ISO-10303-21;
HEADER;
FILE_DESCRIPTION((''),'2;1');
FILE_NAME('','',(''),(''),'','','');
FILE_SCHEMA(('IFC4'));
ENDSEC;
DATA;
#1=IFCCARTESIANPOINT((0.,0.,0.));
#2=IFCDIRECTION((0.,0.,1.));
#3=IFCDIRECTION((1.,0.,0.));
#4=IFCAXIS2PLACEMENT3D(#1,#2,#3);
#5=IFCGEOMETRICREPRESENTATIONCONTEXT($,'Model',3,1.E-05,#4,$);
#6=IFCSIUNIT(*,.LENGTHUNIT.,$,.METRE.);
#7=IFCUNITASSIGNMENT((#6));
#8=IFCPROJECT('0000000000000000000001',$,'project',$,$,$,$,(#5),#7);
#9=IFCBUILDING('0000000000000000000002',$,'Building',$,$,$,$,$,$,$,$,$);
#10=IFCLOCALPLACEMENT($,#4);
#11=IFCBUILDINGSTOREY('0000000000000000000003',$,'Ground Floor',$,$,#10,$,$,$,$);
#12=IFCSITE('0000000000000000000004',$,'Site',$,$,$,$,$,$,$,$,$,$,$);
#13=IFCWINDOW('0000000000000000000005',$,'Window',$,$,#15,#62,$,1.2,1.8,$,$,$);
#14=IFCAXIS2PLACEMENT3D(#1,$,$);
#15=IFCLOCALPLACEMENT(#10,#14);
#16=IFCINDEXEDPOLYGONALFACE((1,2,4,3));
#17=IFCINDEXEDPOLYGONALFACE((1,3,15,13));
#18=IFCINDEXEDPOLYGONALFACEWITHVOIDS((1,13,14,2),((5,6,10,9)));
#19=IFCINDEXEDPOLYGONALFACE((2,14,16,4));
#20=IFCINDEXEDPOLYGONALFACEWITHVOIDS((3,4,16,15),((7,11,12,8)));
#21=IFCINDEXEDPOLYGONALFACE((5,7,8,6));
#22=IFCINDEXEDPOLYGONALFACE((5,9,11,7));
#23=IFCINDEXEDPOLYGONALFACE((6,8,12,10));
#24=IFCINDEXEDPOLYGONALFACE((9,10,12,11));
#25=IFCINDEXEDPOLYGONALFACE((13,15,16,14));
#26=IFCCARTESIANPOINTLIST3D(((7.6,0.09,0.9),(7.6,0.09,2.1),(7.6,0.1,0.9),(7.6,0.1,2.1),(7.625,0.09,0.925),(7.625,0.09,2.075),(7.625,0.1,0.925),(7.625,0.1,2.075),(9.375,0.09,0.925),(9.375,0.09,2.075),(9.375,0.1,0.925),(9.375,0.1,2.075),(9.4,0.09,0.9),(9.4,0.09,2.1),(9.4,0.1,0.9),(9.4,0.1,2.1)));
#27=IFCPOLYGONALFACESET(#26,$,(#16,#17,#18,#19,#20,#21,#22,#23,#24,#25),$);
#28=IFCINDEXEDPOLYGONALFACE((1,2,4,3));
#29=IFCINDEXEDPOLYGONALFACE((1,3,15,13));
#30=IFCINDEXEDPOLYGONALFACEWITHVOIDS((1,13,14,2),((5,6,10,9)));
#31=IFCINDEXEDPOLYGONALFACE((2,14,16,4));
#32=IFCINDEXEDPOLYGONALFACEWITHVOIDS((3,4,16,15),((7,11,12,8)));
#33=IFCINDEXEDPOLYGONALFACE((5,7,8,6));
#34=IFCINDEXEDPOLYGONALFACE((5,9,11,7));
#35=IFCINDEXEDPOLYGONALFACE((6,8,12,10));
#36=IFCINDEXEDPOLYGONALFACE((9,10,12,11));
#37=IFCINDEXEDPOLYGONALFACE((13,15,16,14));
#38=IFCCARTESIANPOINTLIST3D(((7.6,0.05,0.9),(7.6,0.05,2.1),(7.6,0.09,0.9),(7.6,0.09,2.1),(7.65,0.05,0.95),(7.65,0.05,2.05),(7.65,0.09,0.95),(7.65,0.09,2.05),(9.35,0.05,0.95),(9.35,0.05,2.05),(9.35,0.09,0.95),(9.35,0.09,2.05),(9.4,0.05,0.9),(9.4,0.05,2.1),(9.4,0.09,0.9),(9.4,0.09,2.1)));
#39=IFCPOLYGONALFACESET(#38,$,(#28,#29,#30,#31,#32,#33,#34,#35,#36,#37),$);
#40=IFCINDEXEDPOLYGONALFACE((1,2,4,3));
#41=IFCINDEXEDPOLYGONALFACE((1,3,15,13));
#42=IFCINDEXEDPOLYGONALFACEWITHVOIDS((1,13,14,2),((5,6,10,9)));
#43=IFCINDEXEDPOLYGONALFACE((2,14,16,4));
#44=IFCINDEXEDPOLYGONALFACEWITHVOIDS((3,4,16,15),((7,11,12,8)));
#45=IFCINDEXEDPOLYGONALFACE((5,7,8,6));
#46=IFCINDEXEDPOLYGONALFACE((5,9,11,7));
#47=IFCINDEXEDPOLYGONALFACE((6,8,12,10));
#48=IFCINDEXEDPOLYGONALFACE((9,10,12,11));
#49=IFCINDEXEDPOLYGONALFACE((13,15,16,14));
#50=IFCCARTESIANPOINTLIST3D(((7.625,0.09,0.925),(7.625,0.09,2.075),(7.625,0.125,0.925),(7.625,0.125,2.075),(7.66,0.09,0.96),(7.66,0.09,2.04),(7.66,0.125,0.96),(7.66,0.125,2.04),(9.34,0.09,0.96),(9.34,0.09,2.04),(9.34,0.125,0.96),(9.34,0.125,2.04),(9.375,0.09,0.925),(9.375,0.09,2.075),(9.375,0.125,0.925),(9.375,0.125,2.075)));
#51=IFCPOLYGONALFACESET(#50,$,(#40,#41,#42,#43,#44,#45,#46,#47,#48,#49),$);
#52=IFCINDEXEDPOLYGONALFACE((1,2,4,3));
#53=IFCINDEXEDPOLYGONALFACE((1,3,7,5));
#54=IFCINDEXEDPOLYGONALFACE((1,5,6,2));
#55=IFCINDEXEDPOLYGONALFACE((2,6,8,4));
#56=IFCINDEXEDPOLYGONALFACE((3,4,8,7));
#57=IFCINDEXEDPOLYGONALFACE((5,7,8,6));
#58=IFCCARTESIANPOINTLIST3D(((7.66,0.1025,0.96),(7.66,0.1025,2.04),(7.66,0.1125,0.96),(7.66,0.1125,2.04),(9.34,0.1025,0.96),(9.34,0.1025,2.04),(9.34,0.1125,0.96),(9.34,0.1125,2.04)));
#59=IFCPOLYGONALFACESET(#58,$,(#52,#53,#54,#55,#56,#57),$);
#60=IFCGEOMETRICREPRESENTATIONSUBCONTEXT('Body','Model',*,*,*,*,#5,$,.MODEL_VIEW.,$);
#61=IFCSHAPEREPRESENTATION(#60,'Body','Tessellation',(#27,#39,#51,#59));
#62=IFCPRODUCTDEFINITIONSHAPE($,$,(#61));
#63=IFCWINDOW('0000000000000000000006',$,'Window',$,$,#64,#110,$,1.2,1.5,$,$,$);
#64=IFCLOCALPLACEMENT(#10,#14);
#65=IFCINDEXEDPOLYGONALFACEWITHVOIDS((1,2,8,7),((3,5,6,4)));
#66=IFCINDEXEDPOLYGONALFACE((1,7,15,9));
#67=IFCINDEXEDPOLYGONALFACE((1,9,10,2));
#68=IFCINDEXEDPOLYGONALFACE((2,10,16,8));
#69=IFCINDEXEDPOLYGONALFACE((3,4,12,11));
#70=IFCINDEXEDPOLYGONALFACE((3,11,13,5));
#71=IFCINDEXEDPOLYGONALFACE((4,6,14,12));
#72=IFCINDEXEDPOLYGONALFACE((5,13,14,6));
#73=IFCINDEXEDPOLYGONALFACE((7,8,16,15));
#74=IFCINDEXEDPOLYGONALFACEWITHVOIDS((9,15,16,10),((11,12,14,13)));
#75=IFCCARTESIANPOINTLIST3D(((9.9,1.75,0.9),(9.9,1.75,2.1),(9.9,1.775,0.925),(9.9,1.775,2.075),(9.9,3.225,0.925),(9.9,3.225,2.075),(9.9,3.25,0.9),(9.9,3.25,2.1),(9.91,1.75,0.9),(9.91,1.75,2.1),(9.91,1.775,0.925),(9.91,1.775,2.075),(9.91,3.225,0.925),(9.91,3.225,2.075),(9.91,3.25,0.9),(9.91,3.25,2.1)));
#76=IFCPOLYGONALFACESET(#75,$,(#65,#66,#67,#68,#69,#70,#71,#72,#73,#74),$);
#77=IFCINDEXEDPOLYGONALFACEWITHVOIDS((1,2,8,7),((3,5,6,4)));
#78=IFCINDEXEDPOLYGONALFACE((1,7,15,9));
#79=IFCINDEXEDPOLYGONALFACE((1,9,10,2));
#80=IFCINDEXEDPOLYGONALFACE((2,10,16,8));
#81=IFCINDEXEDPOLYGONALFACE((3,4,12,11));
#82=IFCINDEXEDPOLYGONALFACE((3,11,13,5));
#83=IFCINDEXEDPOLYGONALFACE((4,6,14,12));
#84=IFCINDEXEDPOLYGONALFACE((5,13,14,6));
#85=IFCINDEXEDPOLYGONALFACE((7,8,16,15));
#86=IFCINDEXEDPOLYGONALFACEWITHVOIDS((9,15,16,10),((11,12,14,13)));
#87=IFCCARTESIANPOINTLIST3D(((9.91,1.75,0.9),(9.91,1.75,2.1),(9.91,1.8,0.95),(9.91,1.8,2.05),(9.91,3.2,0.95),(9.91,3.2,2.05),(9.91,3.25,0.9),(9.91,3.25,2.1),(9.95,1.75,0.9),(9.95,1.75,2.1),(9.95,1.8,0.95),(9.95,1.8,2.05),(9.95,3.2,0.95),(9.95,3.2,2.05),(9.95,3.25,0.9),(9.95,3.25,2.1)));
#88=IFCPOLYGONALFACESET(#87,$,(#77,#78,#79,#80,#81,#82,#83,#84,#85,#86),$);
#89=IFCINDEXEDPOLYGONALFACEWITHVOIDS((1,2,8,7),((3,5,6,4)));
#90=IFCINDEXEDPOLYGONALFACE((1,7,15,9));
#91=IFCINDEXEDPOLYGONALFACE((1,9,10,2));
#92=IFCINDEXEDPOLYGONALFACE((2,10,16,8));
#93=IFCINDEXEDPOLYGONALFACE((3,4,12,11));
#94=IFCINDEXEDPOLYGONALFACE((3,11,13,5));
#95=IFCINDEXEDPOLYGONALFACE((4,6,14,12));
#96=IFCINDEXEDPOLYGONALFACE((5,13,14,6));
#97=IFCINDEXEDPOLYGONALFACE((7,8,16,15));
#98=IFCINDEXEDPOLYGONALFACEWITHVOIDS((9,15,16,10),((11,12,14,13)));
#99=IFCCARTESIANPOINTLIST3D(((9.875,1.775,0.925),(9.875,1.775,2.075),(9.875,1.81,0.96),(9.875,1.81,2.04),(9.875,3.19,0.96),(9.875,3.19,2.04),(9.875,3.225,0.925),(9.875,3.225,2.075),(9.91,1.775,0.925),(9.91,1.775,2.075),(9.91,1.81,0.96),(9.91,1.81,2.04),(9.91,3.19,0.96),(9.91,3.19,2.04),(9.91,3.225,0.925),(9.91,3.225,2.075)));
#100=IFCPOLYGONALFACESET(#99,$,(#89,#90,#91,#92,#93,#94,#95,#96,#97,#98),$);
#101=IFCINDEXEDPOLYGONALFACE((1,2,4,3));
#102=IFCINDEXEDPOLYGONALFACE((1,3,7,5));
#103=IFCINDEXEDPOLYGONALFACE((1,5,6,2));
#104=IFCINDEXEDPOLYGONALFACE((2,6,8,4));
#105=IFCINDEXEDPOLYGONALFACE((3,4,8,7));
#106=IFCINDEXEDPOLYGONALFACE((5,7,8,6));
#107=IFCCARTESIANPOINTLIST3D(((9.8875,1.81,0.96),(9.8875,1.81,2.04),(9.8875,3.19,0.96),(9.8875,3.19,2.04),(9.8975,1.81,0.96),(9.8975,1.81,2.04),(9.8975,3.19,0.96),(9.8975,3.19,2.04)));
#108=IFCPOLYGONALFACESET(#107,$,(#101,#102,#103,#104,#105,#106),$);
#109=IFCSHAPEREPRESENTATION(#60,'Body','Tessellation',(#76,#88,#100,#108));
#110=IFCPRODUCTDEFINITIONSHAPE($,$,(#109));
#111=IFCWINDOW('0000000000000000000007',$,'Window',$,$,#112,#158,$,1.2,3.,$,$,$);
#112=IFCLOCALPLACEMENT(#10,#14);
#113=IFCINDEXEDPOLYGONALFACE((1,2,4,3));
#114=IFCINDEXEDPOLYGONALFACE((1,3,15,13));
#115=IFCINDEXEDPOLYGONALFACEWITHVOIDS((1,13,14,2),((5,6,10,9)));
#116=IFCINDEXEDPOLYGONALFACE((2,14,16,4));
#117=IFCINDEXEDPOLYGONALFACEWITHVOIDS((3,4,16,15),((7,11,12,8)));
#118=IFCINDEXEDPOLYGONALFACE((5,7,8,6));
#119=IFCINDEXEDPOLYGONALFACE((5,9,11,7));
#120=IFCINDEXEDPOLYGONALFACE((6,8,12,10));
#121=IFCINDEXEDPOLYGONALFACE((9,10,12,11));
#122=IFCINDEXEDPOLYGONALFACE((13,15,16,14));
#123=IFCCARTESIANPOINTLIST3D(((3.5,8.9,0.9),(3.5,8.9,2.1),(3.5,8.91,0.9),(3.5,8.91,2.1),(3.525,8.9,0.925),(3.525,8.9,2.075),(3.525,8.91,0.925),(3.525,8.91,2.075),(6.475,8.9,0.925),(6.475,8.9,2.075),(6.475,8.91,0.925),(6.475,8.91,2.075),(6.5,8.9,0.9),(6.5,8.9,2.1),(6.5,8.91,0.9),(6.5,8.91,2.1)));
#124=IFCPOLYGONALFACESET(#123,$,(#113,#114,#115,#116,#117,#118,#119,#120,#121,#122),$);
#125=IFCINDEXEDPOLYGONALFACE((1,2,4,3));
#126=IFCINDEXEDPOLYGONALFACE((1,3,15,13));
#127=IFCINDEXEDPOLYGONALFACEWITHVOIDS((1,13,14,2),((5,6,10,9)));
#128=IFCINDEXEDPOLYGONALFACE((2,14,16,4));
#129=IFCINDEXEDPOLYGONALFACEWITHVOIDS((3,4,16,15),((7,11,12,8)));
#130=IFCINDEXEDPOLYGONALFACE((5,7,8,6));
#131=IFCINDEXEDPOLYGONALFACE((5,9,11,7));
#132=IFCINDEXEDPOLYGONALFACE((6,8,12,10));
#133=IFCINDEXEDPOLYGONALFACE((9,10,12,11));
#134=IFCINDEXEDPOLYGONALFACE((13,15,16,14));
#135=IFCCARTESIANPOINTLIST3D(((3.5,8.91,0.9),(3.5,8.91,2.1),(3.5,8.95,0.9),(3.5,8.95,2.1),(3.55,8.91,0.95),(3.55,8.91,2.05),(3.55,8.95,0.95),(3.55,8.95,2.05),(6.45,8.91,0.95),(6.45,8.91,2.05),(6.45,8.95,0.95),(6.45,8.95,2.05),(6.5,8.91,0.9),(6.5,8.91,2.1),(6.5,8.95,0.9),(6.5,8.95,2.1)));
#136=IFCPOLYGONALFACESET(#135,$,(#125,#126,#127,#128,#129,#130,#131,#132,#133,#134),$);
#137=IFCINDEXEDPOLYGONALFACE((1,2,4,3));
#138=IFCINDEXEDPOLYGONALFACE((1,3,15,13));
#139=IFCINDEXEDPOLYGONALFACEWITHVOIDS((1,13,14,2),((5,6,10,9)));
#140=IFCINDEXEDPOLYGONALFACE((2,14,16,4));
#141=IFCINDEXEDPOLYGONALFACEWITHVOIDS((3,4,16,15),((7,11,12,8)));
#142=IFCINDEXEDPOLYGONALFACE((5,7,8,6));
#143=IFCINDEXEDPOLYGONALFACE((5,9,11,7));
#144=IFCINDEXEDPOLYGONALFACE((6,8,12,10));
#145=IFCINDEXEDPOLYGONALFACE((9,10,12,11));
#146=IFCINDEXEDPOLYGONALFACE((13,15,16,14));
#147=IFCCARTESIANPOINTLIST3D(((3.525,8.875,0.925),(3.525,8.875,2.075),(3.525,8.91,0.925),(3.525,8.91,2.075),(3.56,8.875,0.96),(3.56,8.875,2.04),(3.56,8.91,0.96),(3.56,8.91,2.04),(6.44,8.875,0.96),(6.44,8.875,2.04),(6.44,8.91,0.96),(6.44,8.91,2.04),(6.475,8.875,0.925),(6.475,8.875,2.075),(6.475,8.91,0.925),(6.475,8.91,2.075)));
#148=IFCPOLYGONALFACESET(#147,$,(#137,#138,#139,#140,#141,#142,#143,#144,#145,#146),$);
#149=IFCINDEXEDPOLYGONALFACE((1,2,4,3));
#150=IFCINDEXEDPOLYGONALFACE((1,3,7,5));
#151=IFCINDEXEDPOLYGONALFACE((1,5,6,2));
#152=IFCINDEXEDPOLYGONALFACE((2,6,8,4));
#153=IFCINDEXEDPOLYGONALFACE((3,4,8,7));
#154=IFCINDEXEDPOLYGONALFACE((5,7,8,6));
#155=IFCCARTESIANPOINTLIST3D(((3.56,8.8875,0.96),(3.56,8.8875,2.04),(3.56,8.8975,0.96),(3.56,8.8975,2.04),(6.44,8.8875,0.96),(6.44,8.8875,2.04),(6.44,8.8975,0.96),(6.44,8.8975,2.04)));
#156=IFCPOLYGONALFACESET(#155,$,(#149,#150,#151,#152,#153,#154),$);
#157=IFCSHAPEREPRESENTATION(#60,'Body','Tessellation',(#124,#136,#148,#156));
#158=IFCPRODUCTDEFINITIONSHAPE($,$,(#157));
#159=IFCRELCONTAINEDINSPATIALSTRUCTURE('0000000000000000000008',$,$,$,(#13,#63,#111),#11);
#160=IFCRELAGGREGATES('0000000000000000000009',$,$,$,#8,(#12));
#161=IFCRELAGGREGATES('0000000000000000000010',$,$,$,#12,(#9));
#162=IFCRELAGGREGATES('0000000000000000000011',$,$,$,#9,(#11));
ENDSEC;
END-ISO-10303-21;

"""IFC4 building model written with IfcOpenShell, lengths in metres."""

from ifc_helpers import new_model, si_unit, frame, origin_with_axes, place, context, subcontext, project, spatial, line, indexed_curve, outline, extrude, element, save


model = new_model("IFC4")

# Units and contexts
model_context = context("Model", 3, precision=1e-05, world=origin_with_axes())
body_context = subcontext(model_context, "Body", "Model", "MODEL_VIEW")
ifc_project = project(units=[si_unit("LENGTHUNIT", "METRE")], contexts=[model_context])

# Site, building, storey
site = spatial("IfcSite", under=ifc_project, Name="Site")
building = spatial("IfcBuilding", under=site, Name="Building")
storey_placement = place(None, origin_with_axes())
storey = spatial("IfcBuildingStorey", under=building, at=storey_placement, Name="Ground Floor")

# Windows
window_1_placement = place(storey_placement, frame((7.6, 0.0, 0.9), z_axis=(0.0, 0.0, 1.0), x_axis=(1.0, 0.0, 0.0)))
element("IfcWindow", 1, at=window_1_placement, inside=storey, Name="Window", OverallHeight=1.2, OverallWidth=1.8, context=body_context, shape_type="SweptSolid", body=[
    extrude(outline(indexed_curve([(0.0, 0.0), (1.8, 0.0), (1.8, 1.2), (0.0, 1.2)], segments=[line(1, 2, 3, 4, 1)]), holes=[indexed_curve([(0.025, 0.025), (1.775, 0.025), (1.775, 1.175), (0.025, 1.175)], segments=[line(1, 2, 3, 4, 1)])]), frame((0.0, 0.09, 0.0), z_axis=(0.0, -1.0, 0.0), x_axis=(1.0, 0.0, 0.0)), (0.0, 0.0, -1.0), 0.01),
    extrude(outline(indexed_curve([(0.0, 0.0), (1.8, 0.0), (1.8, 1.2), (0.0, 1.2)], segments=[line(1, 2, 3, 4, 1)]), holes=[indexed_curve([(0.05, 0.05), (1.75, 0.05), (1.75, 1.15), (0.05, 1.15)], segments=[line(1, 2, 3, 4, 1)])]), frame((0.0, 0.05, 0.0), z_axis=(0.0, -1.0, 0.0), x_axis=(1.0, 0.0, 0.0)), (0.0, 0.0, -1.0), 0.04),
    extrude(outline(indexed_curve([(0.0, 0.0), (1.75, 0.0), (1.75, 1.15), (0.0, 1.15)], segments=[line(1, 2, 3, 4, 1)]), holes=[indexed_curve([(0.035, 0.035), (1.715, 0.035), (1.715, 1.115), (0.035, 1.115)], segments=[line(1, 2, 3, 4, 1)])]), frame((0.025, 0.09, 0.025), z_axis=(0.0, -1.0, 0.0), x_axis=(1.0, 0.0, 0.0)), (0.0, 0.0, -1.0), 0.035),
    extrude(outline(indexed_curve([(0.035, 0.035), (1.715, 0.035), (1.715, 1.115), (0.035, 1.115)], segments=[line(1, 2, 3, 4, 1)])), frame((0.025, 0.1025, 0.025), z_axis=(0.0, -1.0, 0.0), x_axis=(1.0, 0.0, 0.0)), (0.0, 0.0, -1.0), 0.01),
])
window_2_placement = place(storey_placement, frame((10.0, 1.75, 0.9), z_axis=(0.0, 0.0, 1.0), x_axis=(0.0, 1.0, 0.0)))
element("IfcWindow", 2, at=window_2_placement, inside=storey, Name="Window", OverallHeight=1.2, OverallWidth=1.5, context=body_context, shape_type="SweptSolid", body=[
    extrude(outline(indexed_curve([(0.0, 0.0), (1.5, 0.0), (1.5, 1.2), (0.0, 1.2)], segments=[line(1, 2, 3, 4, 1)]), holes=[indexed_curve([(0.025, 0.025), (1.475, 0.025), (1.475, 1.175), (0.025, 1.175)], segments=[line(1, 2, 3, 4, 1)])]), frame((0.0, 0.09, 0.0), z_axis=(0.0, -1.0, 0.0), x_axis=(1.0, 0.0, 0.0)), (0.0, 0.0, -1.0), 0.01),
    extrude(outline(indexed_curve([(0.0, 0.0), (1.5, 0.0), (1.5, 1.2), (0.0, 1.2)], segments=[line(1, 2, 3, 4, 1)]), holes=[indexed_curve([(0.05, 0.05), (1.45, 0.05), (1.45, 1.15), (0.05, 1.15)], segments=[line(1, 2, 3, 4, 1)])]), frame((0.0, 0.05, 0.0), z_axis=(0.0, -1.0, 0.0), x_axis=(1.0, 0.0, 0.0)), (0.0, 0.0, -1.0), 0.04),
    extrude(outline(indexed_curve([(0.0, 0.0), (1.45, 0.0), (1.45, 1.15), (0.0, 1.15)], segments=[line(1, 2, 3, 4, 1)]), holes=[indexed_curve([(0.035, 0.035), (1.415, 0.035), (1.415, 1.115), (0.035, 1.115)], segments=[line(1, 2, 3, 4, 1)])]), frame((0.025, 0.09, 0.025), z_axis=(0.0, -1.0, 0.0), x_axis=(1.0, 0.0, 0.0)), (0.0, 0.0, -1.0), 0.035),
    extrude(outline(indexed_curve([(0.035, 0.035), (1.415, 0.035), (1.415, 1.115), (0.035, 1.115)], segments=[line(1, 2, 3, 4, 1)])), frame((0.025, 0.1025, 0.025), z_axis=(0.0, -1.0, 0.0), x_axis=(1.0, 0.0, 0.0)), (0.0, 0.0, -1.0), 0.01),
])
window_3_placement = place(storey_placement, frame((6.5, 9.0, 0.9), z_axis=(0.0, 0.0, 1.0), x_axis=(-1.0, 0.0, 0.0)))
element("IfcWindow", 3, at=window_3_placement, inside=storey, Name="Window", OverallHeight=1.2, OverallWidth=3.0, context=body_context, shape_type="SweptSolid", body=[
    extrude(outline(indexed_curve([(0.0, 0.0), (3.0, 0.0), (3.0, 1.2), (0.0, 1.2)], segments=[line(1, 2, 3, 4, 1)]), holes=[indexed_curve([(0.025, 0.025), (2.975, 0.025), (2.975, 1.175), (0.025, 1.175)], segments=[line(1, 2, 3, 4, 1)])]), frame((0.0, 0.09, 0.0), z_axis=(0.0, -1.0, 0.0), x_axis=(1.0, 0.0, 0.0)), (0.0, 0.0, -1.0), 0.01),
    extrude(outline(indexed_curve([(0.0, 0.0), (3.0, 0.0), (3.0, 1.2), (0.0, 1.2)], segments=[line(1, 2, 3, 4, 1)]), holes=[indexed_curve([(0.05, 0.05), (2.95, 0.05), (2.95, 1.15), (0.05, 1.15)], segments=[line(1, 2, 3, 4, 1)])]), frame((0.0, 0.05, 0.0), z_axis=(0.0, -1.0, 0.0), x_axis=(1.0, 0.0, 0.0)), (0.0, 0.0, -1.0), 0.04),
    extrude(outline(indexed_curve([(0.0, 0.0), (2.95, 0.0), (2.95, 1.15), (0.0, 1.15)], segments=[line(1, 2, 3, 4, 1)]), holes=[indexed_curve([(0.035, 0.035), (2.915, 0.035), (2.915, 1.115), (0.035, 1.115)], segments=[line(1, 2, 3, 4, 1)])]), frame((0.025, 0.09, 0.025), z_axis=(0.0, -1.0, 0.0), x_axis=(1.0, 0.0, 0.0)), (0.0, 0.0, -1.0), 0.035),
    extrude(outline(indexed_curve([(0.035, 0.035), (2.915, 0.035), (2.915, 1.115), (0.035, 1.115)], segments=[line(1, 2, 3, 4, 1)])), frame((0.025, 0.1025, 0.025), z_axis=(0.0, -1.0, 0.0), x_axis=(1.0, 0.0, 0.0)), (0.0, 0.0, -1.0), 0.01),
])

save(model, "model.ifc")
